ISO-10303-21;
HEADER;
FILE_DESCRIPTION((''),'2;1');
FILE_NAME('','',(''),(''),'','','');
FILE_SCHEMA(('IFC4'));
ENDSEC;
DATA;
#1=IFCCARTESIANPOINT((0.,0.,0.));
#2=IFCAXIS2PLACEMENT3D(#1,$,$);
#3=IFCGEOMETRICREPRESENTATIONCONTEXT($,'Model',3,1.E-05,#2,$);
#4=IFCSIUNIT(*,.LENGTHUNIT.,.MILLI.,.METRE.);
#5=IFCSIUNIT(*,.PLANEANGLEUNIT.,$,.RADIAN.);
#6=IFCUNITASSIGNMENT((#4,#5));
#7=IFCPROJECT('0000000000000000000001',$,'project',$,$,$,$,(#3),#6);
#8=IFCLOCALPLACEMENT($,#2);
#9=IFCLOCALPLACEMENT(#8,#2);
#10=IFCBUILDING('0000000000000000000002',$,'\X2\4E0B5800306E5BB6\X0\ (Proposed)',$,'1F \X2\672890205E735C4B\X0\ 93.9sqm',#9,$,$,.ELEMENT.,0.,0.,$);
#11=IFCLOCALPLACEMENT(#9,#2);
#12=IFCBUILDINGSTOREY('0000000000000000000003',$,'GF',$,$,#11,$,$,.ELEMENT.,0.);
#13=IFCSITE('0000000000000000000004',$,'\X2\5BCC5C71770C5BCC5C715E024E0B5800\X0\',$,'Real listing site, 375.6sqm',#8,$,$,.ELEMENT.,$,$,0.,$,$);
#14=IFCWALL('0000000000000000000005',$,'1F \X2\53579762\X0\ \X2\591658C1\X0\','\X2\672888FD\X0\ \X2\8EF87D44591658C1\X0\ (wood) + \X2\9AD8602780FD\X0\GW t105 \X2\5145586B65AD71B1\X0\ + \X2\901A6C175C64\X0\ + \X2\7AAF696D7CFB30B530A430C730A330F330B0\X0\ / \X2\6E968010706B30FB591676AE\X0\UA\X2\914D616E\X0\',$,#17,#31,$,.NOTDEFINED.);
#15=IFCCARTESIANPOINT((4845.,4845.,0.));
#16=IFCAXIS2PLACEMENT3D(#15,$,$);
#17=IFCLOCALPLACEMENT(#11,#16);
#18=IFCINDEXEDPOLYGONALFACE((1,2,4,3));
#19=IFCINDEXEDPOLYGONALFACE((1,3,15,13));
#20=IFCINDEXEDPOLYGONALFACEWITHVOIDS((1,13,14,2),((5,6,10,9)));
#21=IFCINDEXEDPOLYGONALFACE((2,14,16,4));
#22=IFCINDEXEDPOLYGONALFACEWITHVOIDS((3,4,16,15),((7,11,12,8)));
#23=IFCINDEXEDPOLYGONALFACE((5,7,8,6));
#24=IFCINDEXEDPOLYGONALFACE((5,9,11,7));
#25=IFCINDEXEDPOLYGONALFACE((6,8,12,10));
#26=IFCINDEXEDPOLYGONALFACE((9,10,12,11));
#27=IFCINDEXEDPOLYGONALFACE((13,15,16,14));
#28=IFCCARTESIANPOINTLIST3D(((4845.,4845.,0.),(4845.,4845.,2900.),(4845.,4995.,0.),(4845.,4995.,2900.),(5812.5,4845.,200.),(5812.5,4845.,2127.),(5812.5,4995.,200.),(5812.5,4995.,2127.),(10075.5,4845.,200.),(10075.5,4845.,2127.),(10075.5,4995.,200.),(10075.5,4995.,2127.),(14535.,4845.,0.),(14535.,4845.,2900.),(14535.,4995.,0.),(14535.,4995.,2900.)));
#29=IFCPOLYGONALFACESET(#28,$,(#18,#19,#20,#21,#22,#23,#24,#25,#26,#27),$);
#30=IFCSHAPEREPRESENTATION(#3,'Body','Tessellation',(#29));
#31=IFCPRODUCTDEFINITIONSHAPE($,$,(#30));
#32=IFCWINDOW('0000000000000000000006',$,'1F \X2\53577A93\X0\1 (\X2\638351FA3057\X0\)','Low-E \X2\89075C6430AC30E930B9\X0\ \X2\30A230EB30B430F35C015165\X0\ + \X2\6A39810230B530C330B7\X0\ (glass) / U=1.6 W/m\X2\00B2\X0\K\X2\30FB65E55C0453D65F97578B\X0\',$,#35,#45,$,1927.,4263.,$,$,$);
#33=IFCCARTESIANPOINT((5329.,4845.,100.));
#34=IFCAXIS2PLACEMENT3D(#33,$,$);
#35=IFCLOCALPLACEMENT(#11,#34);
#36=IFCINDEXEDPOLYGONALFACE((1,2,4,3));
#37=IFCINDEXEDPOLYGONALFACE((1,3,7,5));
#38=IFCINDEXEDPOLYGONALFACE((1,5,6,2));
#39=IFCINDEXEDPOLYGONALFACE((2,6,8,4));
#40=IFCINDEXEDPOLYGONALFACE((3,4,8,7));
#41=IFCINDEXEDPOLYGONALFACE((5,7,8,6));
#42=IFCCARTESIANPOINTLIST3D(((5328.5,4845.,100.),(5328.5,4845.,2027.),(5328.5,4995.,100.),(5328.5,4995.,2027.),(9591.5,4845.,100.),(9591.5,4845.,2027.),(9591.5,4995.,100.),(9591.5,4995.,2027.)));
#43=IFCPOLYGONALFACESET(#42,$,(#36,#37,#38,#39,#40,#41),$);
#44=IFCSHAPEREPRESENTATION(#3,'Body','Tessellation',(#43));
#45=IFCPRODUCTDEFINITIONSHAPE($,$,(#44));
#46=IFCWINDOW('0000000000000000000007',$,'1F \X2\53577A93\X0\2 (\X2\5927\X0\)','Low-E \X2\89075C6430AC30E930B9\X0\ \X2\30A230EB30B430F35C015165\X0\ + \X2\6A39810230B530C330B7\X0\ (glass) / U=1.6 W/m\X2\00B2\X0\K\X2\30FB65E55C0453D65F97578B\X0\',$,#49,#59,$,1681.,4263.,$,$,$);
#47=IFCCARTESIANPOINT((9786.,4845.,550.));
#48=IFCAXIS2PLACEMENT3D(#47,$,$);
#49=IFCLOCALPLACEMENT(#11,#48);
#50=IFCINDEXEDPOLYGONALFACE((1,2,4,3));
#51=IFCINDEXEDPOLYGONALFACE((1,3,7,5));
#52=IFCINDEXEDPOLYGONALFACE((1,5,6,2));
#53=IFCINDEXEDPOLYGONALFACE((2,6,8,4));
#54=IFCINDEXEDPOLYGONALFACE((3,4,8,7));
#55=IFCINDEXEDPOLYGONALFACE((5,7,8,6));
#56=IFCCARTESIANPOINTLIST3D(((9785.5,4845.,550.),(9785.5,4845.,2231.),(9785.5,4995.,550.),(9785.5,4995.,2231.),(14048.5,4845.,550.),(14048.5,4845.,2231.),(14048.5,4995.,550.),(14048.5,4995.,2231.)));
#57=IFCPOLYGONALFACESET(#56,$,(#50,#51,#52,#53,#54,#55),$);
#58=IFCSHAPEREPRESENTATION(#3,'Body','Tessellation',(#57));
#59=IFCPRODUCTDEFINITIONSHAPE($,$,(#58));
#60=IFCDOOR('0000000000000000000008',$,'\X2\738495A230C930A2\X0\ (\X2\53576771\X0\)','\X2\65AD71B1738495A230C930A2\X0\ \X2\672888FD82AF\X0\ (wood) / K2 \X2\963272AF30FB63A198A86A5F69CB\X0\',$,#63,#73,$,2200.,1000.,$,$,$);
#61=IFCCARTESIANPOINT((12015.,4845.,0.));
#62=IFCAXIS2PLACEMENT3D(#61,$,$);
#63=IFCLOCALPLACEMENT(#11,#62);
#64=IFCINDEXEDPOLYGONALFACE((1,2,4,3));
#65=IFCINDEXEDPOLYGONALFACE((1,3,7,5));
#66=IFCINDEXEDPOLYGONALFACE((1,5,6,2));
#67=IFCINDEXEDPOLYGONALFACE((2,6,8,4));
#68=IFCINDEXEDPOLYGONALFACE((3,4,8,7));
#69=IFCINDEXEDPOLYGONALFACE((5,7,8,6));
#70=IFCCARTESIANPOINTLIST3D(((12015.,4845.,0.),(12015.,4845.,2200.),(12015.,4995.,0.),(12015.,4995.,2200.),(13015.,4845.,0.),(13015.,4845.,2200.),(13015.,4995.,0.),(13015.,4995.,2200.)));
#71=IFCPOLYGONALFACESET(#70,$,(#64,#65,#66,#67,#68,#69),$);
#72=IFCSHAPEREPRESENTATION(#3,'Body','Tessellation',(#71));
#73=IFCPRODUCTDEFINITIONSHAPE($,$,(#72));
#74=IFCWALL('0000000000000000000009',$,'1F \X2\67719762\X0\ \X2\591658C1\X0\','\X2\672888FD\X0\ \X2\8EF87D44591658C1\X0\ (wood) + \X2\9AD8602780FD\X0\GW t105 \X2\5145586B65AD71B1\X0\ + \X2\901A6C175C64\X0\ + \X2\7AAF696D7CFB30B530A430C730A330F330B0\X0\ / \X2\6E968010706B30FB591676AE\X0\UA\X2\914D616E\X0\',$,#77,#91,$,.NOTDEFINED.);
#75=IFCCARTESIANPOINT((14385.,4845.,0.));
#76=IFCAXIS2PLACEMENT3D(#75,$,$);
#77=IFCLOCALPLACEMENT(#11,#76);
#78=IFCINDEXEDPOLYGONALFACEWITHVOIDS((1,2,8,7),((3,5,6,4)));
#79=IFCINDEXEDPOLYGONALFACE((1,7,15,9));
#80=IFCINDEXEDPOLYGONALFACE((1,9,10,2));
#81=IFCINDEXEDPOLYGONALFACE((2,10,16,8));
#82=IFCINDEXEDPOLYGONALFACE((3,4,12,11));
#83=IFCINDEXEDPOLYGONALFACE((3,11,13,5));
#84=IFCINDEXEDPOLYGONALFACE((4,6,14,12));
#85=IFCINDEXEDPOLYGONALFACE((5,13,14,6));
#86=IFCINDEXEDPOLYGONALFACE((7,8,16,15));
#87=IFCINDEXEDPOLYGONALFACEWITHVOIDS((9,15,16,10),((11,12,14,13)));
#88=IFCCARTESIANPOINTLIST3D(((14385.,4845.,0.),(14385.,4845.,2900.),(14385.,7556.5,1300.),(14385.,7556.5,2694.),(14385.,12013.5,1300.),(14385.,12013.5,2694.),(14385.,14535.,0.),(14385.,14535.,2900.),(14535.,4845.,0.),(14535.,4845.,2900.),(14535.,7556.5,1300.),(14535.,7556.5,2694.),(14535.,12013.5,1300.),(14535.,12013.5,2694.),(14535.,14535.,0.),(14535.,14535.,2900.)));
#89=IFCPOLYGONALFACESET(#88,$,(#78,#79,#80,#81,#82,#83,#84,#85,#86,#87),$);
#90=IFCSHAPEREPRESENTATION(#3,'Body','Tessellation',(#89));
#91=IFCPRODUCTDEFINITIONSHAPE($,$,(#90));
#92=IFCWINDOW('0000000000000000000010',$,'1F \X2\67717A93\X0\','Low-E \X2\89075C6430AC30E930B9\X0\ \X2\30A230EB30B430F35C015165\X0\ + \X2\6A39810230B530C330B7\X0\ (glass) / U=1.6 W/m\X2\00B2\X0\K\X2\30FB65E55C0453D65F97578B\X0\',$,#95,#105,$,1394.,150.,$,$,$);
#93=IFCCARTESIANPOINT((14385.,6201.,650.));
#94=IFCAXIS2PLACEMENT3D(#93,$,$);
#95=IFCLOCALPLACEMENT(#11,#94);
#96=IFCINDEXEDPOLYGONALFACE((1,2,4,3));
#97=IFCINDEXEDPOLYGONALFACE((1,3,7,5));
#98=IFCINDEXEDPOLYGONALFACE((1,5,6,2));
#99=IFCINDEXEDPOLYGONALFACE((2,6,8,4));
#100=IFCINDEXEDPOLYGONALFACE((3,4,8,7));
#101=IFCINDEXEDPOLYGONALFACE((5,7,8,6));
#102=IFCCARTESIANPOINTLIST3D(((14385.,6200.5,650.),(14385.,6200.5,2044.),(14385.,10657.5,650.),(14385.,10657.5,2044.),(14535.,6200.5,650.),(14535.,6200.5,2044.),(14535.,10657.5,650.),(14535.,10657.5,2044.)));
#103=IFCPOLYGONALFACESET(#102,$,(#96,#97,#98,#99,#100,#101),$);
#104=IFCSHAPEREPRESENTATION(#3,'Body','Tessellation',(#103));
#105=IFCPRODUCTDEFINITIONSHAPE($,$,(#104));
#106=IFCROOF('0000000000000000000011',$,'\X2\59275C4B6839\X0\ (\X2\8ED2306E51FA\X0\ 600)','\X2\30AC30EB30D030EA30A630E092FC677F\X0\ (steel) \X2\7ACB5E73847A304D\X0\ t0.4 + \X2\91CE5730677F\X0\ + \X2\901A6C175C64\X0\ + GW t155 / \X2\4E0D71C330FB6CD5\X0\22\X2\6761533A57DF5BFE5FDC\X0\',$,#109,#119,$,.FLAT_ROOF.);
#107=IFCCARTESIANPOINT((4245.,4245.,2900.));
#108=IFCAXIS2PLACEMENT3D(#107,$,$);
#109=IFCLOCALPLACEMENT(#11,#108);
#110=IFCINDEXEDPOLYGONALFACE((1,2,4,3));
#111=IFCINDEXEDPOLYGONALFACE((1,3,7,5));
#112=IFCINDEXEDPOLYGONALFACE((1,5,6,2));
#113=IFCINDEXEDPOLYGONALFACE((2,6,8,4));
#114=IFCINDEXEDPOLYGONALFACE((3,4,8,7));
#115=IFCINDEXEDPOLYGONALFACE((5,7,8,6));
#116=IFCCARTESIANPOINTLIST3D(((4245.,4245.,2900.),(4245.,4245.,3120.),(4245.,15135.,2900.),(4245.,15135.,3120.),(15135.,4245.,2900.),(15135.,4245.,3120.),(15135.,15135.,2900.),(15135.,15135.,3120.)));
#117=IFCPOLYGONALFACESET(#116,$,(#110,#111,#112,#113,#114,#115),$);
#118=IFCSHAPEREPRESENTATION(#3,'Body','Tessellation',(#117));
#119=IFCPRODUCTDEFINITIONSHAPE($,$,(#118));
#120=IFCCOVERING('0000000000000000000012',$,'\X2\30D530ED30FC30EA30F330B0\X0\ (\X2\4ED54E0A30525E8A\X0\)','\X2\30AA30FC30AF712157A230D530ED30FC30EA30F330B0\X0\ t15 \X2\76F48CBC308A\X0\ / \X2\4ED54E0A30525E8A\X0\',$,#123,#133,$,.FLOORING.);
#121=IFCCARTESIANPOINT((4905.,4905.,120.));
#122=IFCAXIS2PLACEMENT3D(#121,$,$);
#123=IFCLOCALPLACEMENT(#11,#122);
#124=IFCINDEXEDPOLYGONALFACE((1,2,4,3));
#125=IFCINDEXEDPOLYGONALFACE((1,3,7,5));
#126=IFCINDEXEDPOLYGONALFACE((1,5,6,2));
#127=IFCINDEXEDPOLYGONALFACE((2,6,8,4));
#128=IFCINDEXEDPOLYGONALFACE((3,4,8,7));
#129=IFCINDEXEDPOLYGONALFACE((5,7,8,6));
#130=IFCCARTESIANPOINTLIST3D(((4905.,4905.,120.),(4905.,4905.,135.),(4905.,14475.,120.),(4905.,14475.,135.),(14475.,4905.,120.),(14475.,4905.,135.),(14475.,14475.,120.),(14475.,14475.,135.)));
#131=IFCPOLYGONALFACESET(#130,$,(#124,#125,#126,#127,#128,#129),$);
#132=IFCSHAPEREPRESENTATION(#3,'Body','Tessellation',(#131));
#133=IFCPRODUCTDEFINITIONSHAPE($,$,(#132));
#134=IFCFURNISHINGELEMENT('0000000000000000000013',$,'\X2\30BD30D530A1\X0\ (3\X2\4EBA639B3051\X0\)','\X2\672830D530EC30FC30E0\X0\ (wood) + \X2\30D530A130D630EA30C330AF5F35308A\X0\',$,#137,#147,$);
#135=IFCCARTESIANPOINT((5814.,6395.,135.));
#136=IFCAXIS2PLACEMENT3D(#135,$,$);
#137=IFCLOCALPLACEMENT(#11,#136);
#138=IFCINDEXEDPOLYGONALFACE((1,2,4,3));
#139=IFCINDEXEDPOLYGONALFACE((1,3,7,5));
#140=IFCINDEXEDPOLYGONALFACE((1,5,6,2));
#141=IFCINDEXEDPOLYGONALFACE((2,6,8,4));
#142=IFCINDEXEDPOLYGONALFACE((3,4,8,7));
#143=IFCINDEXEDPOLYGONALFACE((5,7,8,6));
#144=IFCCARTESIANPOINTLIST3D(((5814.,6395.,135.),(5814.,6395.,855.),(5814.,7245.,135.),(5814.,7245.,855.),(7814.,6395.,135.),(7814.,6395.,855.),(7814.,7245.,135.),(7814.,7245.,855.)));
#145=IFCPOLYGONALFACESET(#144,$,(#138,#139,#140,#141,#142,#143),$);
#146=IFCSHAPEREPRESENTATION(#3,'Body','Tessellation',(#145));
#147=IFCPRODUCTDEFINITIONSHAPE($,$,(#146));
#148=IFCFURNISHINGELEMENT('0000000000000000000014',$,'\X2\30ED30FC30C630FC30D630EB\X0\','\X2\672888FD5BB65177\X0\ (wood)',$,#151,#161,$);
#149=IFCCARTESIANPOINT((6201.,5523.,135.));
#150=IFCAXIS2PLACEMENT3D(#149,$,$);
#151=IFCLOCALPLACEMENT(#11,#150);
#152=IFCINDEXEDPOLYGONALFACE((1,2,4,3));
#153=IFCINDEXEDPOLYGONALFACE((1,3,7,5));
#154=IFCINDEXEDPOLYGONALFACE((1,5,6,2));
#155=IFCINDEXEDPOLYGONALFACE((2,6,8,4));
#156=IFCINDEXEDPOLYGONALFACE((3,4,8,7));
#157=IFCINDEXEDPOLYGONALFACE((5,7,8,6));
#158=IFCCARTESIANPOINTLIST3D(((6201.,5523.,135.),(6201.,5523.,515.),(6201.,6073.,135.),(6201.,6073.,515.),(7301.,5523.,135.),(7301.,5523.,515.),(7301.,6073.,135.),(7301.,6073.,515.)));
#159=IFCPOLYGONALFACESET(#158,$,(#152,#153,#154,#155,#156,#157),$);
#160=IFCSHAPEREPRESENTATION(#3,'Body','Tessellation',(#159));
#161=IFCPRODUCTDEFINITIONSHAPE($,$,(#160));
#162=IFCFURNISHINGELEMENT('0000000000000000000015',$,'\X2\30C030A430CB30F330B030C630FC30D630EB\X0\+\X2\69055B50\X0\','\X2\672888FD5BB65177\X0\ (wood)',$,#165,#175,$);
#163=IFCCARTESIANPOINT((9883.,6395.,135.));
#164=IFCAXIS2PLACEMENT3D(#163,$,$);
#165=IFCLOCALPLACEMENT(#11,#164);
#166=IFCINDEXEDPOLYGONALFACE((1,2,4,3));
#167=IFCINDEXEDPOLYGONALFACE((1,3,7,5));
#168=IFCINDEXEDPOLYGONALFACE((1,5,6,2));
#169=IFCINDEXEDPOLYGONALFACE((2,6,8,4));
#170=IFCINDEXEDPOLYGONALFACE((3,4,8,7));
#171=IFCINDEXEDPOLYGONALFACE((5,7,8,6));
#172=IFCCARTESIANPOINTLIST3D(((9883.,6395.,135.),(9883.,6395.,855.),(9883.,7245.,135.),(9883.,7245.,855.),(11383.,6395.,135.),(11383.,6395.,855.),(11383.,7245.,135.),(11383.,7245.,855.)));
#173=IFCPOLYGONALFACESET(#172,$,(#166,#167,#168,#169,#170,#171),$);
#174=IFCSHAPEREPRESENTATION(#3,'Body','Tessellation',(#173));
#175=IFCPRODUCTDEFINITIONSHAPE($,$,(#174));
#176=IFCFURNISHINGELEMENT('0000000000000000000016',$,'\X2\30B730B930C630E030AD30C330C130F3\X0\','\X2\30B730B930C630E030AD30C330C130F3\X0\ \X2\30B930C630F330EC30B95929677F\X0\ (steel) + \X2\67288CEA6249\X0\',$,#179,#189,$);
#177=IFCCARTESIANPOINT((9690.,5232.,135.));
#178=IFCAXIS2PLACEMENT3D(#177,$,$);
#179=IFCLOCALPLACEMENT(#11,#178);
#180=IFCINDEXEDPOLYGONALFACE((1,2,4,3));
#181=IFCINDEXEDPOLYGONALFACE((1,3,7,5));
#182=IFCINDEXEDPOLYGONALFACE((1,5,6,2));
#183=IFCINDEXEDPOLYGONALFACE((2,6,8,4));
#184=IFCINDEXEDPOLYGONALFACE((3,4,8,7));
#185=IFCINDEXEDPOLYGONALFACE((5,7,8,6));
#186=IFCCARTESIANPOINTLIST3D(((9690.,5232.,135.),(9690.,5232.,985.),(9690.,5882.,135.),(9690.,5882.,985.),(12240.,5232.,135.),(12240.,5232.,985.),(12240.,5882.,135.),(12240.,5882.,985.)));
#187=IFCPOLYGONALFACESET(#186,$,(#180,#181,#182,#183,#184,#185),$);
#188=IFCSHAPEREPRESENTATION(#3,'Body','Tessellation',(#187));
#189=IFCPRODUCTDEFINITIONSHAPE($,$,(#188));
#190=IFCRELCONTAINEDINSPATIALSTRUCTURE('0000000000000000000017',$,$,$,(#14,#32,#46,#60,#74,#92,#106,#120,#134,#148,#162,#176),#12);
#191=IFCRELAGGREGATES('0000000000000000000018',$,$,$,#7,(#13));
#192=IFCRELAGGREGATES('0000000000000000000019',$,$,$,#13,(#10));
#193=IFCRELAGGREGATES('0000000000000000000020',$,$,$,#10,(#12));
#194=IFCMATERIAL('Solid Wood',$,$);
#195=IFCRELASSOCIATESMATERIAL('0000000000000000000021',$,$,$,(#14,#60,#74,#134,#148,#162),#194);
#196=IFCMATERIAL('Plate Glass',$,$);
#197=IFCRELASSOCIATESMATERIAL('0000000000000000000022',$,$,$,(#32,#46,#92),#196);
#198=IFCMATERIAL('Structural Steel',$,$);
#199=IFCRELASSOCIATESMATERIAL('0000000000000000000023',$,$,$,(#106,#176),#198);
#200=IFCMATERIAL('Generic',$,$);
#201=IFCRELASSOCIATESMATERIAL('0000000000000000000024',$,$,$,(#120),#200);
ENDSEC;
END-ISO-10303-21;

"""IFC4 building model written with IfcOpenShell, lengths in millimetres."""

from ifc_helpers import new_model, si_unit, frame, frame_2d, origin, place, context, project, spatial, rectangle, extrude, material, element, fill, save


model = new_model("IFC4")

# Units and contexts
model_context = context("Model", 3, precision=1e-05, world=origin())
ifc_project = project(units=[si_unit("LENGTHUNIT", "METRE", prefix="MILLI"), si_unit("PLANEANGLEUNIT", "RADIAN")], contexts=[model_context])

# Site, building, storey
site_placement = place(None, origin())
site = spatial("IfcSite", under=ifc_project, at=site_placement, Name="富山県富山市下堀", ObjectType="Real listing site, 375.6sqm", CompositionType="ELEMENT", RefElevation=0.0)
building_placement = place(site_placement, origin())
building = spatial("IfcBuilding", under=site, at=building_placement, Name="下堀の家 (Proposed)", ObjectType="1F 木造平屋 93.9sqm", CompositionType="ELEMENT", ElevationOfRefHeight=0.0, ElevationOfTerrain=0.0)
storey_placement = place(building_placement, origin())
storey = spatial("IfcBuildingStorey", under=building, at=storey_placement, Name="GF", CompositionType="ELEMENT", Elevation=0.0)

# Shared definitions
ifc_material_1 = material(Name="Solid Wood")

# Wall, openings, windows, door
wall_1_placement = place(storey_placement, frame((4845.0, 4845.0, 0.0)))
wall_1 = element("IfcWall", 1, at=wall_1_placement, inside=storey, material=ifc_material_1, Name="1F 南面 外壁", Description="木製 軸組外壁 (wood) + 高性能GW t105 充填断熱 + 通気層 + 窯業系サイディング / 準耐火・外皮UA配慮", PredefinedType="NOTDEFINED", context=model_context, shape_type="SweptSolid", body=[
    extrude(rectangle(XDim=9690.0, YDim=150.0, at=frame_2d((4845.0, 75.0))), frame((4845.0, 4845.0, 0.0)), (0.0, 0.0, 1.0), 2900.0),
])
opening_1_placement = place(storey_placement, frame((5329.0, 4845.0, 100.0)))
opening_1 = element("IfcOpeningElement", 2, at=opening_1_placement, cuts=wall_1, PredefinedType="NOTDEFINED", context=model_context, shape_type="SweptSolid", body=[
    extrude(rectangle(XDim=4263.0, YDim=150.0, at=frame_2d((2131.0, 75.0))), frame((5329.0, 4845.0, 100.0)), (0.0, 0.0, 1.0), 1927.0),
])
opening_2_placement = place(storey_placement, frame((9786.0, 4845.0, 550.0)))
opening_2 = element("IfcOpeningElement", 3, at=opening_2_placement, cuts=wall_1, PredefinedType="NOTDEFINED", context=model_context, shape_type="SweptSolid", body=[
    extrude(rectangle(XDim=4263.0, YDim=150.0, at=frame_2d((2131.0, 75.0))), frame((9786.0, 4845.0, 550.0)), (0.0, 0.0, 1.0), 1681.0),
])
opening_3_placement = place(storey_placement, frame((12015.0, 4845.0, 0.0)))
opening_3 = element("IfcOpeningElement", 4, at=opening_3_placement, cuts=wall_1, PredefinedType="NOTDEFINED", context=model_context, shape_type="SweptSolid", body=[
    extrude(rectangle(XDim=1000.0, YDim=150.0, at=frame_2d((500.0, 75.0))), frame((12015.0, 4845.0, 0.0)), (0.0, 0.0, 1.0), 2200.0),
])
ifc_material_2 = material(Name="Plate Glass")
window_1_placement = place(storey_placement, frame((5329.0, 4845.0, 100.0)))
window_1 = element("IfcWindow", 5, at=window_1_placement, inside=storey, material=ifc_material_2, Name="1F 南窓1 (掃出し)", Description="Low-E 複層ガラス アルゴン封入 + 樹脂サッシ (glass) / U=1.6 W/m²K・日射取得型", OverallHeight=1927.0, OverallWidth=4263.0, context=model_context, shape_type="SweptSolid", body=[
    extrude(rectangle(XDim=4263.0, YDim=150.0, at=frame_2d((2131.0, 75.0))), frame((5329.0, 4845.0, 100.0)), (0.0, 0.0, 1.0), 1927.0),
])
fill(opening_1, window_1)
window_2_placement = place(storey_placement, frame((9786.0, 4845.0, 550.0)))
window_2 = element("IfcWindow", 6, at=window_2_placement, inside=storey, material=ifc_material_2, Name="1F 南窓2 (大)", Description="Low-E 複層ガラス アルゴン封入 + 樹脂サッシ (glass) / U=1.6 W/m²K・日射取得型", OverallHeight=1681.0, OverallWidth=4263.0, context=model_context, shape_type="SweptSolid", body=[
    extrude(rectangle(XDim=4263.0, YDim=150.0, at=frame_2d((2131.0, 75.0))), frame((9786.0, 4845.0, 550.0)), (0.0, 0.0, 1.0), 1681.0),
])
fill(opening_2, window_2)
door_placement = place(storey_placement, frame((12015.0, 4845.0, 0.0)))
door = element("IfcDoor", 7, at=door_placement, inside=storey, material=ifc_material_1, Name="玄関ドア (南東)", Description="断熱玄関ドア 木製芯 (wood) / K2 防犯・採風機構", OverallHeight=2200.0, OverallWidth=1000.0, context=model_context, shape_type="SweptSolid", body=[
    extrude(rectangle(XDim=1000.0, YDim=150.0, at=frame_2d((500.0, 75.0))), frame((12015.0, 4845.0, 0.0)), (0.0, 0.0, 1.0), 2200.0),
])
fill(opening_3, door)

# Wall, opening, window
wall_2_placement = place(storey_placement, frame((14385.0, 4845.0, 0.0)))
wall_2 = element("IfcWall", 8, at=wall_2_placement, inside=storey, material=ifc_material_1, Name="1F 東面 外壁", Description="木製 軸組外壁 (wood) + 高性能GW t105 充填断熱 + 通気層 + 窯業系サイディング / 準耐火・外皮UA配慮", PredefinedType="NOTDEFINED", context=model_context, shape_type="SweptSolid", body=[
    extrude(rectangle(XDim=150.0, YDim=9690.0, at=frame_2d((75.0, 4845.0))), frame((14385.0, 4845.0, 0.0)), (0.0, 0.0, 1.0), 2900.0),
])
opening_4_placement = place(storey_placement, frame((14385.0, 6201.0, 650.0)))
opening_4 = element("IfcOpeningElement", 9, at=opening_4_placement, cuts=wall_2, PredefinedType="NOTDEFINED", context=model_context, shape_type="SweptSolid", body=[
    extrude(rectangle(XDim=150.0, YDim=4457.0, at=frame_2d((75.0, 2228.0))), frame((14385.0, 6201.0, 650.0)), (0.0, 0.0, 1.0), 1394.0),
])
window_3_placement = place(storey_placement, frame((14385.0, 6201.0, 650.0)))
window_3 = element("IfcWindow", 10, at=window_3_placement, inside=storey, material=ifc_material_2, Name="1F 東窓", Description="Low-E 複層ガラス アルゴン封入 + 樹脂サッシ (glass) / U=1.6 W/m²K・日射取得型", OverallHeight=1394.0, OverallWidth=150.0, context=model_context, shape_type="SweptSolid", body=[
    extrude(rectangle(XDim=150.0, YDim=4457.0, at=frame_2d((75.0, 2228.0))), frame((14385.0, 6201.0, 650.0)), (0.0, 0.0, 1.0), 1394.0),
])
fill(opening_4, window_3)

# Roof
ifc_material_3 = material(Name="Structural Steel")
roof_placement = place(storey_placement, frame((4245.0, 4245.0, 2900.0)))
element("IfcRoof", 11, at=roof_placement, inside=storey, material=ifc_material_3, Name="大屋根 (軒の出 600)", Description="ガルバリウム鋼板 (steel) 立平葺き t0.4 + 野地板 + 通気層 + GW t155 / 不燃・法22条区域対応", PredefinedType="FLAT_ROOF", context=model_context, shape_type="SweptSolid", body=[
    extrude(rectangle(XDim=10890.0, YDim=10890.0, at=frame_2d((5445.0, 5445.0))), frame((4245.0, 4245.0, 2900.0)), (0.0, 0.0, 1.0), 220.0),
])

# Covering
ifc_material_4 = material(Name="Generic")
covering_placement = place(storey_placement, frame((4905.0, 4905.0, 120.0)))
element("IfcCovering", 12, at=covering_placement, inside=storey, material=ifc_material_4, Name="フローリング (仕上げ床)", Description="オーク無垢フローリング t15 直貼り / 仕上げ床", PredefinedType="FLOORING", context=model_context, shape_type="SweptSolid", body=[
    extrude(rectangle(XDim=9570.0, YDim=9570.0, at=frame_2d((4785.0, 4785.0))), frame((4905.0, 4905.0, 120.0)), (0.0, 0.0, 1.0), 15.0),
])

# Furnishing elements
furnishing_1_placement = place(storey_placement, frame((5814.0, 6395.0, 135.0)))
element("IfcFurnishingElement", 13, at=furnishing_1_placement, inside=storey, material=ifc_material_1, Name="ソファ (3人掛け)", Description="木フレーム (wood) + ファブリック張り", context=model_context, shape_type="SweptSolid", body=[
    extrude(rectangle(XDim=2000.0, YDim=850.0, at=frame_2d((1000.0, 425.0))), frame((5814.0, 6395.0, 135.0)), (0.0, 0.0, 1.0), 720.0),
])
furnishing_2_placement = place(storey_placement, frame((6201.0, 5523.0, 135.0)))
element("IfcFurnishingElement", 14, at=furnishing_2_placement, inside=storey, material=ifc_material_1, Name="ローテーブル", Description="木製家具 (wood)", context=model_context, shape_type="SweptSolid", body=[
    extrude(rectangle(XDim=1100.0, YDim=550.0, at=frame_2d((550.0, 275.0))), frame((6201.0, 5523.0, 135.0)), (0.0, 0.0, 1.0), 380.0),
])
furnishing_3_placement = place(storey_placement, frame((9883.0, 6395.0, 135.0)))
element("IfcFurnishingElement", 15, at=furnishing_3_placement, inside=storey, material=ifc_material_1, Name="ダイニングテーブル+椅子", Description="木製家具 (wood)", context=model_context, shape_type="SweptSolid", body=[
    extrude(rectangle(XDim=1500.0, YDim=850.0, at=frame_2d((750.0, 425.0))), frame((9883.0, 6395.0, 135.0)), (0.0, 0.0, 1.0), 720.0),
])
furnishing_4_placement = place(storey_placement, frame((9690.0, 5232.0, 135.0)))
element("IfcFurnishingElement", 16, at=furnishing_4_placement, inside=storey, material=ifc_material_3, Name="システムキッチン", Description="システムキッチン ステンレス天板 (steel) + 木質扉", context=model_context, shape_type="SweptSolid", body=[
    extrude(rectangle(XDim=2550.0, YDim=650.0, at=frame_2d((1275.0, 325.0))), frame((9690.0, 5232.0, 135.0)), (0.0, 0.0, 1.0), 850.0),
])

save(model, "model.ifc")
